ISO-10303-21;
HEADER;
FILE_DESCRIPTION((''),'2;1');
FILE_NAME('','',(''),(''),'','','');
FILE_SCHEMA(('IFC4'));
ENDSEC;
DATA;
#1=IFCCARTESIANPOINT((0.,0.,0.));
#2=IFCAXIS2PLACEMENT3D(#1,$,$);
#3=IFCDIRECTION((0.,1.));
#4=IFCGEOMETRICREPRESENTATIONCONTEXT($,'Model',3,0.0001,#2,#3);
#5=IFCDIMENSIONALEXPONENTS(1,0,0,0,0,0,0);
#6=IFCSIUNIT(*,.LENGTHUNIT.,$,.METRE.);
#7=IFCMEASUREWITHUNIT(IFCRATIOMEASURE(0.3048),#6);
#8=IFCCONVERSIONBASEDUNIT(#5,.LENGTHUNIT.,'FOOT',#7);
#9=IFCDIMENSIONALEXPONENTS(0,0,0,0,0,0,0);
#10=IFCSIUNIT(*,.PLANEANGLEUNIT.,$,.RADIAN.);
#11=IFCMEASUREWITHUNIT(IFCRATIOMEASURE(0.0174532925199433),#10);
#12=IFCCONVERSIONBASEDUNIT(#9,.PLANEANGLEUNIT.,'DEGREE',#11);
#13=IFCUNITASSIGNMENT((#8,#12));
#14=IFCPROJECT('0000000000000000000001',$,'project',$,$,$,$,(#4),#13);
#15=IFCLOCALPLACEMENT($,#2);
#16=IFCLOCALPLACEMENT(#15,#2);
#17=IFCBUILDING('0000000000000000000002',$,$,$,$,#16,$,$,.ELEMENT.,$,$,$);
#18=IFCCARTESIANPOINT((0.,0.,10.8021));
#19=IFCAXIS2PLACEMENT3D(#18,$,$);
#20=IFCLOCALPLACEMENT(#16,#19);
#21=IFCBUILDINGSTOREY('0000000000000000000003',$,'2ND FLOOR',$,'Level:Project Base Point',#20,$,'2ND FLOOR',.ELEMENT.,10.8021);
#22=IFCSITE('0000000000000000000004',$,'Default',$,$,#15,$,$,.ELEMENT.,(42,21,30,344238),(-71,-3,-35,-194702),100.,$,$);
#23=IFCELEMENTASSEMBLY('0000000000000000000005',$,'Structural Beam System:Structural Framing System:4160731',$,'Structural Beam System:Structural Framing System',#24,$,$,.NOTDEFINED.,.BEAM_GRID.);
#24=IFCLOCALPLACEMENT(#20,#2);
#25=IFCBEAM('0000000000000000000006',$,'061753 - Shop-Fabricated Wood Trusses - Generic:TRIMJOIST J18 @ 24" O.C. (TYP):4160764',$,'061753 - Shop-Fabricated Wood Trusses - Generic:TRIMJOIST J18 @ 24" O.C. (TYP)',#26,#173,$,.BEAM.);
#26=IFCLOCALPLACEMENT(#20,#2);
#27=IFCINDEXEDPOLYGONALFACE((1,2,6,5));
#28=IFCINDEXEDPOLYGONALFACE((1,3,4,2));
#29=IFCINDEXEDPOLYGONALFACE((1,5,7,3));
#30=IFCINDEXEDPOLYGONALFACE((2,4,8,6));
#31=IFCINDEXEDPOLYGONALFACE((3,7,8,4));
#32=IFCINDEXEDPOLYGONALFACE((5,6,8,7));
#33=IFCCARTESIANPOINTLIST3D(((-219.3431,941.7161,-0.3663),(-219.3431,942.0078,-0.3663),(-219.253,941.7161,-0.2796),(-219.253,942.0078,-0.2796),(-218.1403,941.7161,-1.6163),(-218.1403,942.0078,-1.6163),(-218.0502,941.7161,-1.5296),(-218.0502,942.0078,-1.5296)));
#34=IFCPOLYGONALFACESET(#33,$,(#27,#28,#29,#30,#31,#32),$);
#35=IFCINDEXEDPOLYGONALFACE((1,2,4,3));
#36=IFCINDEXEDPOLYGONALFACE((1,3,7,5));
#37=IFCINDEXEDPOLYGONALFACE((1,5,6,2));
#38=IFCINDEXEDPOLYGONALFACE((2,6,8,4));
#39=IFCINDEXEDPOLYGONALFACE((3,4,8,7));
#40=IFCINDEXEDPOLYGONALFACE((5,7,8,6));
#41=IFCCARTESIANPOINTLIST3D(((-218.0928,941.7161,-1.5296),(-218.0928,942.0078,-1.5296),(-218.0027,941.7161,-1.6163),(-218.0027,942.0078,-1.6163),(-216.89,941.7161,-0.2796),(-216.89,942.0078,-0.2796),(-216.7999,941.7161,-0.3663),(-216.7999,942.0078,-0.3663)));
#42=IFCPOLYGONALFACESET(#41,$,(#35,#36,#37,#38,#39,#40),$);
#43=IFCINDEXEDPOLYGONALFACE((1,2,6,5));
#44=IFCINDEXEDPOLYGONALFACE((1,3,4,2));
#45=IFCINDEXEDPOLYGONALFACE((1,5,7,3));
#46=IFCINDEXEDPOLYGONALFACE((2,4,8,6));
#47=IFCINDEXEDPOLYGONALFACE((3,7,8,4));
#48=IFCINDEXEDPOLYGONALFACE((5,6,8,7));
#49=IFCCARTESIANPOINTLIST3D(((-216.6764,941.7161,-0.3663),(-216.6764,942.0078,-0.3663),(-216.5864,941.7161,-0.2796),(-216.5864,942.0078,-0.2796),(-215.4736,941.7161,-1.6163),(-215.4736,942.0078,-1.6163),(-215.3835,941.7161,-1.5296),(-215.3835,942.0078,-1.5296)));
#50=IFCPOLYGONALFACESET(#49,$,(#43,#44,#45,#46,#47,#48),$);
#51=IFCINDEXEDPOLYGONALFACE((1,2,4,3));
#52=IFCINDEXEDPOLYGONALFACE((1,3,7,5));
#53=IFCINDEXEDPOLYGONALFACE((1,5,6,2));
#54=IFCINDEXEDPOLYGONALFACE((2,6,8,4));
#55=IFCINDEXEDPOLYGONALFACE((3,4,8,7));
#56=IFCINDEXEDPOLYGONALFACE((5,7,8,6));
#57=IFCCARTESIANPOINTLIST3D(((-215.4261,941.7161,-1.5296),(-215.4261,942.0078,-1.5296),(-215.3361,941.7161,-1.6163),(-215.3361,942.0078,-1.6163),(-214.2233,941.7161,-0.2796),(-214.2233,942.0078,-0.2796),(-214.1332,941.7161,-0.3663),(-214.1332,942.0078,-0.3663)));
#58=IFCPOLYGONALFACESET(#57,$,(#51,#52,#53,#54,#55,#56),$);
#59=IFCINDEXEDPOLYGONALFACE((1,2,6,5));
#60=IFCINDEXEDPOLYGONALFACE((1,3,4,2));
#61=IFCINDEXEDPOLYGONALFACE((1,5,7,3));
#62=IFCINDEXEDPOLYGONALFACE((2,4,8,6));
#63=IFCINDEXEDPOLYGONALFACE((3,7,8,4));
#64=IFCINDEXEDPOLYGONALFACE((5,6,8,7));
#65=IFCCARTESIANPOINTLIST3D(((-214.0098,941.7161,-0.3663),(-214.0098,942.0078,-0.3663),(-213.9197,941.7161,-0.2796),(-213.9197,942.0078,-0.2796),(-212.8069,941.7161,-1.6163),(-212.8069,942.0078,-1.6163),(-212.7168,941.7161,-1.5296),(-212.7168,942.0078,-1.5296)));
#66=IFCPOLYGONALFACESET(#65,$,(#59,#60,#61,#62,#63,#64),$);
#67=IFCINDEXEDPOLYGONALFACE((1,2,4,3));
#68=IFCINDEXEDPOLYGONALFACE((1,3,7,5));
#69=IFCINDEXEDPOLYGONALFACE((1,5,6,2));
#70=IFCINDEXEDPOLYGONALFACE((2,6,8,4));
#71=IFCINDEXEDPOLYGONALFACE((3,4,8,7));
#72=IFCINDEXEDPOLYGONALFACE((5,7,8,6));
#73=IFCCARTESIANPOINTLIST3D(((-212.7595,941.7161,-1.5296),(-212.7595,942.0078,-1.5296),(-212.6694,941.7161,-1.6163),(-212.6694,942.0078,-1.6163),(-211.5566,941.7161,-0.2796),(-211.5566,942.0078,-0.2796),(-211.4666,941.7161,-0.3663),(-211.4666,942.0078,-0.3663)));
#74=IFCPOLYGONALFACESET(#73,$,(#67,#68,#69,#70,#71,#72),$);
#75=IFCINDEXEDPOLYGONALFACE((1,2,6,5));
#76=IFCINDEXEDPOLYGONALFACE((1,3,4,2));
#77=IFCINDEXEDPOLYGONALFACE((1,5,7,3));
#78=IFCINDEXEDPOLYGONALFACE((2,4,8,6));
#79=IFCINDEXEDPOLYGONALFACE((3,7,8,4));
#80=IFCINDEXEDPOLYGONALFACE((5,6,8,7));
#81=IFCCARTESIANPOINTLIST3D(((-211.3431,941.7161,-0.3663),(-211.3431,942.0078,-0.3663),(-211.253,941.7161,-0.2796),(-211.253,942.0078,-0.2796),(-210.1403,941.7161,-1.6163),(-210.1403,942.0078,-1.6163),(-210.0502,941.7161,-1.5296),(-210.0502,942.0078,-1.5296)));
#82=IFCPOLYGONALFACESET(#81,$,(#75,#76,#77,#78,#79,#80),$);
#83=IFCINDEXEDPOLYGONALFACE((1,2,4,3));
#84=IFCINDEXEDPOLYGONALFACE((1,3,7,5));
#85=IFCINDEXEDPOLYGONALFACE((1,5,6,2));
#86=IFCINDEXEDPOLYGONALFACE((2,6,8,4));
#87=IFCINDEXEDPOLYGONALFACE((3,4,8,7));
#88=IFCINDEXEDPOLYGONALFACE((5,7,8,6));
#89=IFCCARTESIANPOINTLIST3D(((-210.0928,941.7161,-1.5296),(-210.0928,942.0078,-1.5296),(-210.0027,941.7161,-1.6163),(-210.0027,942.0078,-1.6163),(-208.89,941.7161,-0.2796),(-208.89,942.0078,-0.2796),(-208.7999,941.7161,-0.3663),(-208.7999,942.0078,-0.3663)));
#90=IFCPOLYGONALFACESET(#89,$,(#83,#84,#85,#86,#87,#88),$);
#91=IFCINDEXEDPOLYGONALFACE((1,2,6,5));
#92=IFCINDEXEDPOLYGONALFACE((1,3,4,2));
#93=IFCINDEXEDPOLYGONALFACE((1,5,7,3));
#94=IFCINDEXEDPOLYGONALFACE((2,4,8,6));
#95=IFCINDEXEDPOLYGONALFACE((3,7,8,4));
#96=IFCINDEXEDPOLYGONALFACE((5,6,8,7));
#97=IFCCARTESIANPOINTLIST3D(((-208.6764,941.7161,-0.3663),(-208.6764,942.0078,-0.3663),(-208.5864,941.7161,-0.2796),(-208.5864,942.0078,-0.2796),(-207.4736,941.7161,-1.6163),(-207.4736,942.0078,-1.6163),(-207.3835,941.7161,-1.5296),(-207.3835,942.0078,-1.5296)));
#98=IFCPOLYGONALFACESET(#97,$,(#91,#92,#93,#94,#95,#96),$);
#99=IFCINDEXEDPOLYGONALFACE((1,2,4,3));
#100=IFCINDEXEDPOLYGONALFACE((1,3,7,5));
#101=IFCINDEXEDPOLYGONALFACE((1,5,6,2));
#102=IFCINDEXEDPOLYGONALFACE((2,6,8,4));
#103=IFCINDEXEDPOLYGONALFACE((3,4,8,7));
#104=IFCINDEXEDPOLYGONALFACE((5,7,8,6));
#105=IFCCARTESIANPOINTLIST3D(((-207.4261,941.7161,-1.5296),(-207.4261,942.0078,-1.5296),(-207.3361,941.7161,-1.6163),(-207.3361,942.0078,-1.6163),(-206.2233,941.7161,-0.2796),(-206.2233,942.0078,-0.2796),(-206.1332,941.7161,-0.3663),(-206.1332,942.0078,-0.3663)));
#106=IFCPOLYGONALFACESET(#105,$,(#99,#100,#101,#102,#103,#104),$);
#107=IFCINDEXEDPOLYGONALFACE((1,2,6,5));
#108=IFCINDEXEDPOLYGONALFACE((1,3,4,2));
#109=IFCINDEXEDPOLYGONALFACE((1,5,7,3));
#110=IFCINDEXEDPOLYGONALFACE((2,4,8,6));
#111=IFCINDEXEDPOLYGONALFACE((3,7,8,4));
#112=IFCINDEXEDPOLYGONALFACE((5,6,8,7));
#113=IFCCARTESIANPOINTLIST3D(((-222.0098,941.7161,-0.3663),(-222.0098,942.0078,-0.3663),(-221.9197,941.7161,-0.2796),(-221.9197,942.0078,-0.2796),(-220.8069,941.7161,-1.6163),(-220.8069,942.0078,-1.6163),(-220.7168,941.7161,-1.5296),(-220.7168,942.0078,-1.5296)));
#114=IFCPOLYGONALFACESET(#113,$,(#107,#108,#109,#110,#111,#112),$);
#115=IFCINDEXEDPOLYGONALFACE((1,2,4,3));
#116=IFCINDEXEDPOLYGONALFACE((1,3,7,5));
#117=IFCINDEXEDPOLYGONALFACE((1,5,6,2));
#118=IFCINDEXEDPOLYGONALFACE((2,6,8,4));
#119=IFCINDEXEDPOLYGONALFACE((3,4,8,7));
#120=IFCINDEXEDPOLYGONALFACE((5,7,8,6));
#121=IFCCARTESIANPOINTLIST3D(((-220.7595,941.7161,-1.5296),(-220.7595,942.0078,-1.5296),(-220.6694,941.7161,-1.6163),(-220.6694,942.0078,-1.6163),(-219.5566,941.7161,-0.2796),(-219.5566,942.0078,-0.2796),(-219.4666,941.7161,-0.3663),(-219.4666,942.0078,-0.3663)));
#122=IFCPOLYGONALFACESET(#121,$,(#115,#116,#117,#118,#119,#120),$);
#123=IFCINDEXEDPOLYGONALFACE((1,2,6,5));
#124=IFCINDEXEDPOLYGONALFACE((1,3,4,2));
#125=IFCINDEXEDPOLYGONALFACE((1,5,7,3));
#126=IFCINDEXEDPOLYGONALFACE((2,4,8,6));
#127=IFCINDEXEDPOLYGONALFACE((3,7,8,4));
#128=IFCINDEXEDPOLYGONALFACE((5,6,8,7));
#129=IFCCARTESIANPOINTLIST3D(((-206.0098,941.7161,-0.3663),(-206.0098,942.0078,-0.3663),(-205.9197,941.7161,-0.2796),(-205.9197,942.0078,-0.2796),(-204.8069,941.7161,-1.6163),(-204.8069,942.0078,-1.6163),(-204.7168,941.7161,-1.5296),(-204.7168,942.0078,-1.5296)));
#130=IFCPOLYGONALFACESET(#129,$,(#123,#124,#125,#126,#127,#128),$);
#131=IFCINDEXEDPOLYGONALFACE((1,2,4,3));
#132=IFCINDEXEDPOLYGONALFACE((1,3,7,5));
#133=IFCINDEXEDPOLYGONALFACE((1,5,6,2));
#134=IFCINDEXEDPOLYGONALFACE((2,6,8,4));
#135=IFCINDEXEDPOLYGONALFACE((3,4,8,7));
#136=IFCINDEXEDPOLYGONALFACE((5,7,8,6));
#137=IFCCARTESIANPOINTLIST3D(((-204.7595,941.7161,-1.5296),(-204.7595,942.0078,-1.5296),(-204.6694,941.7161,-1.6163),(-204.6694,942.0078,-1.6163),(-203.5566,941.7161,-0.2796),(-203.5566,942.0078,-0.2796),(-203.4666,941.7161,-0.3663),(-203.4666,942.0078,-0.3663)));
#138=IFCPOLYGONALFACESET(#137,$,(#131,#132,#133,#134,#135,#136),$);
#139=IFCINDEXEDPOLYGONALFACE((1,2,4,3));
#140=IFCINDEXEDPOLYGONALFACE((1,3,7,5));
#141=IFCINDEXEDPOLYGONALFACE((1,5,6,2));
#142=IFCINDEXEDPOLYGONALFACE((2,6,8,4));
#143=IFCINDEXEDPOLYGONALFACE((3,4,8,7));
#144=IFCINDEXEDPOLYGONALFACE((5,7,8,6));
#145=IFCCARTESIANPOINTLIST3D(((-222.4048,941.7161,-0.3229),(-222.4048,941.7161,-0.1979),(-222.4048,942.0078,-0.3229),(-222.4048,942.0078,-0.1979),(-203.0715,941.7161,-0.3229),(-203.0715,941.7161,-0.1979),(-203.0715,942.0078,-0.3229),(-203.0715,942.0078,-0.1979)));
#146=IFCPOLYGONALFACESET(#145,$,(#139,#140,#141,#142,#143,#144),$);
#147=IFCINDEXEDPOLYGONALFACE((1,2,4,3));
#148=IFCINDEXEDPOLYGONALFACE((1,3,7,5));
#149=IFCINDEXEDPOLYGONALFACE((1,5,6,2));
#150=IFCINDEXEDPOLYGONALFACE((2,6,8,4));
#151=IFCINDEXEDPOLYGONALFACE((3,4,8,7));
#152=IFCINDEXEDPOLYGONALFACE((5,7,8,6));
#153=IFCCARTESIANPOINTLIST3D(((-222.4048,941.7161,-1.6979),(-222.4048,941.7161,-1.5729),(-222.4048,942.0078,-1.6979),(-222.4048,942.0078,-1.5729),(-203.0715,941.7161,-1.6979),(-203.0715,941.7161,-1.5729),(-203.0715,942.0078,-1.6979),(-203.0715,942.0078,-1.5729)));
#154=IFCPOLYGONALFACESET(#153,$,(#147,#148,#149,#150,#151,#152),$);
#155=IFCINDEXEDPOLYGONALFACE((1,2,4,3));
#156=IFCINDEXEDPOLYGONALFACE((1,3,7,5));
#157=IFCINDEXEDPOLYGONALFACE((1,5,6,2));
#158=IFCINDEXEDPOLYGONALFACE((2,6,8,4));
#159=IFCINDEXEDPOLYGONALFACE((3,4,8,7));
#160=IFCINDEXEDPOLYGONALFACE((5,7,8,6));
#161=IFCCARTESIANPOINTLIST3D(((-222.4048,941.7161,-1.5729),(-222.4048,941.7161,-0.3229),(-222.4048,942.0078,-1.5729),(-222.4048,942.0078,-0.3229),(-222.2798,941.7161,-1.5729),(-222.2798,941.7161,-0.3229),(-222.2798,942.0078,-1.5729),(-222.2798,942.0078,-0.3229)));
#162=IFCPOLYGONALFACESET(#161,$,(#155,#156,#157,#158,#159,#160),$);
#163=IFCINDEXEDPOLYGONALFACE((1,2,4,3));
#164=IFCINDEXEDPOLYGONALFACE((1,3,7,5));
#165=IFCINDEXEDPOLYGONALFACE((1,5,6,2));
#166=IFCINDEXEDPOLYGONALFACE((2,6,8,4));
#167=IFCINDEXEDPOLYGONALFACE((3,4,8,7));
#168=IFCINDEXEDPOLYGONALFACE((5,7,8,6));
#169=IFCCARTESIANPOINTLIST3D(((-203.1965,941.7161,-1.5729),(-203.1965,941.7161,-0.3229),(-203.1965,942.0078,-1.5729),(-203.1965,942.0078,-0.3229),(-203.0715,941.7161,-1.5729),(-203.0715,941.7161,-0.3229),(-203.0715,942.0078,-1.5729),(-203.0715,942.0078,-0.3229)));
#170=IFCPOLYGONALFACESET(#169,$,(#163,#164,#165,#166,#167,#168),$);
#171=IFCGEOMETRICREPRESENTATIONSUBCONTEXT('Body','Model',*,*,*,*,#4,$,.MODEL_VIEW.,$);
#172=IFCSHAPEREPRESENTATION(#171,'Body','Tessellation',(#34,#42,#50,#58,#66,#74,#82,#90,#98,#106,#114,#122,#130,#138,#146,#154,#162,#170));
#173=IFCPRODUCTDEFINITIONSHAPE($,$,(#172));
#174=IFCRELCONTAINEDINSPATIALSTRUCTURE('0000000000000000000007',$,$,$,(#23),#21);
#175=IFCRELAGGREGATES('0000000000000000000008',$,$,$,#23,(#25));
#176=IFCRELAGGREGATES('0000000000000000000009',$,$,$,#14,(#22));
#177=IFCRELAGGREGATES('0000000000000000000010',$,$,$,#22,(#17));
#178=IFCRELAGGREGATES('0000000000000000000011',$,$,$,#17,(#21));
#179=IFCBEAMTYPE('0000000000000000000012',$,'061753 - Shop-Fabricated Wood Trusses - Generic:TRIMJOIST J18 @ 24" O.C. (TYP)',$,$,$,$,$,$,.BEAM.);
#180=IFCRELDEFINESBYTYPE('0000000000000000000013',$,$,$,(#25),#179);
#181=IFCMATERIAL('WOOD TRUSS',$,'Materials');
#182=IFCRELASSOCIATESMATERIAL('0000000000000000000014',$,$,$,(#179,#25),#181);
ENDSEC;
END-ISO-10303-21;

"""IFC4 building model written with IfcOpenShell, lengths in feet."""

from ifc_helpers import new_model, entity, si_unit, converted_unit, direction, frame, frame_2d, origin, origin_2d_with_axis, place, context, subcontext, project, spatial, rectangle, extrude, source, transform, mapped, material, material_profile, profile_set, profile_usage, type_object, type_shapes, element, aggregate, save


model = new_model("IFC4")

# Units and contexts
model_context = context("Model", 3, precision=0.0001, world=origin(), true_north=direction((0.0, 1.0)))
body_context = subcontext(model_context, "Body", "Model", "MODEL_VIEW")
ifc_project = project(units=[converted_unit("LENGTHUNIT", "FOOT", entity("IfcRatioMeasure", 0.3048), si_unit("LENGTHUNIT", "METRE"), dimensions=[1, 0, 0, 0, 0, 0, 0]), converted_unit("PLANEANGLEUNIT", "DEGREE", entity("IfcRatioMeasure", 0.0174532925199433), si_unit("PLANEANGLEUNIT", "RADIAN"), dimensions=[0, 0, 0, 0, 0, 0, 0])], contexts=[model_context])

# Site, building, storey
site_placement = place(None, origin())
site = spatial("IfcSite", under=ifc_project, at=site_placement, Name="Default", CompositionType="ELEMENT", RefLatitude=(42, 21, 30, 344238), RefLongitude=(-71, -3, -35, -194702), RefElevation=100.0)
building_placement = place(site_placement, origin())
building = spatial("IfcBuilding", under=site, at=building_placement, CompositionType="ELEMENT")
storey_placement = place(building_placement, frame((0.0, 0.0, 10.8021)))
storey = spatial("IfcBuildingStorey", under=building, at=storey_placement, Name="2ND FLOOR", ObjectType="Level:Project Base Point", LongName="2ND FLOOR", CompositionType="ELEMENT", Elevation=10.8021)

# Element assembly, beam
ifc_material_1 = material(Name="WOOD TRUSS", Category="Materials")
ifc_material_profile_1 = material_profile(ifc_material_1, rectangle(XDim=1.7347, YDim=0.125, at=frame_2d((0.0, 0.0), x_axis=(1.0, 0.0))), Name="TRIMJOIST J18 @ 24\" O.C. (TYP)")
ifc_material_profile_2 = material_profile(ifc_material_1, rectangle(XDim=1.7347, YDim=0.125, at=frame_2d((0.0, 0.0), x_axis=(1.0, 0.0))), Name="TRIMJOIST J18 @ 24\" O.C. (TYP)")
ifc_material_profile_3 = material_profile(ifc_material_1, rectangle(XDim=1.7347, YDim=0.125, at=frame_2d((0.0, 0.0), x_axis=(1.0, 0.0))), Name="TRIMJOIST J18 @ 24\" O.C. (TYP)")
ifc_material_profile_4 = material_profile(ifc_material_1, rectangle(XDim=1.7347, YDim=0.125, at=frame_2d((0.0, 0.0), x_axis=(1.0, 0.0))), Name="TRIMJOIST J18 @ 24\" O.C. (TYP)")
ifc_material_profile_5 = material_profile(ifc_material_1, rectangle(XDim=1.7347, YDim=0.125, at=frame_2d((0.0, 0.0), x_axis=(1.0, 0.0))), Name="TRIMJOIST J18 @ 24\" O.C. (TYP)")
ifc_material_profile_6 = material_profile(ifc_material_1, rectangle(XDim=1.7347, YDim=0.125, at=frame_2d((0.0, 0.0), x_axis=(1.0, 0.0))), Name="TRIMJOIST J18 @ 24\" O.C. (TYP)")
ifc_material_profile_7 = material_profile(ifc_material_1, rectangle(XDim=1.7347, YDim=0.125, at=frame_2d((0.0, 0.0), x_axis=(1.0, 0.0))), Name="TRIMJOIST J18 @ 24\" O.C. (TYP)")
ifc_material_profile_8 = material_profile(ifc_material_1, rectangle(XDim=1.7347, YDim=0.125, at=frame_2d((0.0, 0.0), x_axis=(1.0, 0.0))), Name="TRIMJOIST J18 @ 24\" O.C. (TYP)")
ifc_material_profile_9 = material_profile(ifc_material_1, rectangle(XDim=1.7347, YDim=0.125, at=frame_2d((0.0, 0.0), x_axis=(1.0, 0.0))), Name="TRIMJOIST J18 @ 24\" O.C. (TYP)")
ifc_material_profile_10 = material_profile(ifc_material_1, rectangle(XDim=1.7347, YDim=0.125, at=origin_2d_with_axis()), Name="TRIMJOIST J18 @ 24\" O.C. (TYP)")
ifc_material_profile_11 = material_profile(ifc_material_1, rectangle(XDim=0.125, YDim=0.2917, at=origin_2d_with_axis()), Name="TRIMJOIST J18 @ 24\" O.C. (TYP)")
ifc_material_profile_12 = material_profile(ifc_material_1, rectangle(XDim=0.125, YDim=0.2917, at=origin_2d_with_axis()), Name="TRIMJOIST J18 @ 24\" O.C. (TYP)")
ifc_material_profile_13 = material_profile(ifc_material_1, rectangle(XDim=1.25, YDim=0.2917, at=origin_2d_with_axis()), Name="TRIMJOIST J18 @ 24\" O.C. (TYP)")
ifc_material_profile_14 = material_profile(ifc_material_1, rectangle(XDim=1.25, YDim=0.2917, at=origin_2d_with_axis()), Name="TRIMJOIST J18 @ 24\" O.C. (TYP)")
ifc_profile_set_1 = profile_set([ifc_material_profile_1, ifc_material_profile_2, ifc_material_profile_3, ifc_material_profile_4, ifc_material_profile_5, ifc_material_profile_6, ifc_material_profile_7, ifc_material_profile_8, ifc_material_profile_9, ifc_material_profile_10, ifc_material_profile_11, ifc_material_profile_12, ifc_material_profile_13, ifc_material_profile_14], Name="TRIMJOIST J18 @ 24\" O.C. (TYP)")
beam_type_1 = type_object("IfcBeamType", Name="061753 - Shop-Fabricated Wood Trusses - Generic:TRIMJOIST J18 @ 24\" O.C. (TYP)", PredefinedType="BEAM", material=ifc_profile_set_1)
shared_shape_1 = source(origin(), body_context, "Body", "SweptSolid", [
    extrude(rectangle(XDim=1.7347, YDim=0.125, at=frame_2d((0.0, 0.0), x_axis=(1.0, 0.0))), frame((5.9585, -0.1458, 0.0), z_axis=(0.0, 1.0, 0.0), x_axis=(0.693383, 0.0, 0.720569)), (0.0, 0.0, 1.0), 0.2917),
    extrude(rectangle(XDim=1.7347, YDim=0.125, at=origin_2d_with_axis()), frame((4.7082, -0.1458, 0.0), z_axis=(0.0, 1.0, 0.0), x_axis=(0.693383, 0.0, -0.720569)), (0.0, 0.0, 1.0), 0.2917),
    extrude(rectangle(XDim=1.7347, YDim=0.125, at=frame_2d((0.0, 0.0), x_axis=(1.0, 0.0))), frame((3.2918, -0.1458, 0.0), z_axis=(0.0, 1.0, 0.0), x_axis=(0.693383, 0.0, 0.720569)), (0.0, 0.0, 1.0), 0.2917),
    extrude(rectangle(XDim=1.7347, YDim=0.125, at=frame_2d((0.0, 0.0), x_axis=(1.0, 0.0))), frame((2.0415, -0.1458, 0.0), z_axis=(0.0, 1.0, 0.0), x_axis=(0.693383, 0.0, -0.720569)), (0.0, 0.0, 1.0), 0.2917),
    extrude(rectangle(XDim=1.7347, YDim=0.125, at=frame_2d((0.0, 0.0), x_axis=(1.0, 0.0))), frame((0.6251, -0.1458, 0.0), z_axis=(0.0, 1.0, 0.0), x_axis=(0.693383, 0.0, 0.720569)), (0.0, 0.0, 1.0), 0.2917),
    extrude(rectangle(XDim=1.7347, YDim=0.125, at=frame_2d((0.0, 0.0), x_axis=(1.0, 0.0))), frame((-0.6251, -0.1458, 0.0), z_axis=(0.0, 1.0, 0.0), x_axis=(0.693383, 0.0, -0.720569)), (0.0, 0.0, 1.0), 0.2917),
    extrude(rectangle(XDim=1.7347, YDim=0.125, at=frame_2d((0.0, 0.0), x_axis=(1.0, 0.0))), frame((-2.0415, -0.1458, 0.0), z_axis=(0.0, 1.0, 0.0), x_axis=(0.693383, 0.0, 0.720569)), (0.0, 0.0, 1.0), 0.2917),
    extrude(rectangle(XDim=1.7347, YDim=0.125, at=origin_2d_with_axis()), frame((-3.2918, -0.1458, 0.0), z_axis=(0.0, 1.0, 0.0), x_axis=(0.693383, 0.0, -0.720569)), (0.0, 0.0, 1.0), 0.2917),
    extrude(rectangle(XDim=1.7347, YDim=0.125, at=frame_2d((0.0, 0.0), x_axis=(1.0, 0.0))), frame((-4.7082, -0.1458, 0.0), z_axis=(0.0, 1.0, 0.0), x_axis=(0.693383, 0.0, 0.720569)), (0.0, 0.0, 1.0), 0.2917),
    extrude(rectangle(XDim=1.7347, YDim=0.125, at=frame_2d((0.0, 0.0), x_axis=(1.0, 0.0))), frame((-5.9585, -0.1458, 0.0), z_axis=(0.0, 1.0, 0.0), x_axis=(0.693383, 0.0, -0.720569)), (0.0, 0.0, 1.0), 0.2917),
    extrude(rectangle(XDim=1.7347, YDim=0.125, at=frame_2d((0.0, 0.0), x_axis=(1.0, 0.0))), frame((8.6251, -0.1458, 0.0), z_axis=(0.0, 1.0, 0.0), x_axis=(0.693383, 0.0, 0.720569)), (0.0, 0.0, 1.0), 0.2917),
    extrude(rectangle(XDim=1.7347, YDim=0.125, at=origin_2d_with_axis()), frame((7.3749, -0.1458, 0.0), z_axis=(0.0, 1.0, 0.0), x_axis=(0.693383, 0.0, -0.720569)), (0.0, 0.0, 1.0), 0.2917),
    extrude(rectangle(XDim=1.7347, YDim=0.125, at=frame_2d((0.0, 0.0), x_axis=(1.0, 0.0))), frame((-7.3749, -0.1458, 0.0), z_axis=(0.0, 1.0, 0.0), x_axis=(0.693383, 0.0, 0.720569)), (0.0, 0.0, 1.0), 0.2917),
    extrude(rectangle(XDim=1.7347, YDim=0.125, at=origin_2d_with_axis()), frame((-8.6251, -0.1458, 0.0), z_axis=(0.0, 1.0, 0.0), x_axis=(0.693383, 0.0, -0.720569)), (0.0, 0.0, 1.0), 0.2917),
    extrude(rectangle(XDim=0.125, YDim=0.2917, at=origin_2d_with_axis()), frame((-9.6667, 0.0, 0.6875), z_axis=(1.0, 0.0, 0.0), x_axis=(0.0, 0.0, -1.0)), (0.0, 0.0, 1.0), 19.3333),
    extrude(rectangle(XDim=0.125, YDim=0.2917, at=origin_2d_with_axis()), frame((-9.6667, 0.0, -0.6875), z_axis=(1.0, 0.0, 0.0), x_axis=(0.0, 0.0, -1.0)), (0.0, 0.0, 1.0), 19.3333),
    extrude(rectangle(XDim=1.25, YDim=0.2917, at=origin_2d_with_axis()), frame((9.5417, 0.0, 0.0), z_axis=(1.0, 0.0, 0.0), x_axis=(0.0, 0.0, -1.0)), (0.0, 0.0, 1.0), 0.125),
    extrude(rectangle(XDim=1.25, YDim=0.2917, at=origin_2d_with_axis()), frame((-9.6667, 0.0, 0.0), z_axis=(1.0, 0.0, 0.0), x_axis=(0.0, 0.0, -1.0)), (0.0, 0.0, 1.0), 0.125),
])
type_shapes(beam_type_1, [shared_shape_1])
assembly_1_placement = place(storey_placement, origin())
assembly_1 = element("IfcElementAssembly", 1, at=assembly_1_placement, inside=storey, Name="Structural Beam System:Structural Framing System:4160731", ObjectType="Structural Beam System:Structural Framing System", AssemblyPlace="NOTDEFINED", PredefinedType="BEAM_GRID")
ifc_profile_usage_1 = profile_usage(ifc_profile_set_1, cardinal=8)
beam_1_placement = place(assembly_1_placement, frame((-212.7382, 941.8619, -0.9479), z_axis=(0.0, 0.0, 1.0), x_axis=(-1.0, 0.0, 0.0)))
beam_1 = element("IfcBeam", 2, at=beam_1_placement, type_object=beam_type_1, material=ifc_profile_usage_1, Name="061753 - Shop-Fabricated Wood Trusses - Generic:TRIMJOIST J18 @ 24\" O.C. (TYP):4160764", ObjectType="061753 - Shop-Fabricated Wood Trusses - Generic:TRIMJOIST J18 @ 24\" O.C. (TYP)", PredefinedType="BEAM", context=body_context, shape_type="MappedRepresentation", body=[
    mapped(shared_shape_1, transform((0.0, 0.0, 0.0), scale=1.0)),
])
aggregate(assembly_1, [beam_1])

save(model, "model.ifc")
